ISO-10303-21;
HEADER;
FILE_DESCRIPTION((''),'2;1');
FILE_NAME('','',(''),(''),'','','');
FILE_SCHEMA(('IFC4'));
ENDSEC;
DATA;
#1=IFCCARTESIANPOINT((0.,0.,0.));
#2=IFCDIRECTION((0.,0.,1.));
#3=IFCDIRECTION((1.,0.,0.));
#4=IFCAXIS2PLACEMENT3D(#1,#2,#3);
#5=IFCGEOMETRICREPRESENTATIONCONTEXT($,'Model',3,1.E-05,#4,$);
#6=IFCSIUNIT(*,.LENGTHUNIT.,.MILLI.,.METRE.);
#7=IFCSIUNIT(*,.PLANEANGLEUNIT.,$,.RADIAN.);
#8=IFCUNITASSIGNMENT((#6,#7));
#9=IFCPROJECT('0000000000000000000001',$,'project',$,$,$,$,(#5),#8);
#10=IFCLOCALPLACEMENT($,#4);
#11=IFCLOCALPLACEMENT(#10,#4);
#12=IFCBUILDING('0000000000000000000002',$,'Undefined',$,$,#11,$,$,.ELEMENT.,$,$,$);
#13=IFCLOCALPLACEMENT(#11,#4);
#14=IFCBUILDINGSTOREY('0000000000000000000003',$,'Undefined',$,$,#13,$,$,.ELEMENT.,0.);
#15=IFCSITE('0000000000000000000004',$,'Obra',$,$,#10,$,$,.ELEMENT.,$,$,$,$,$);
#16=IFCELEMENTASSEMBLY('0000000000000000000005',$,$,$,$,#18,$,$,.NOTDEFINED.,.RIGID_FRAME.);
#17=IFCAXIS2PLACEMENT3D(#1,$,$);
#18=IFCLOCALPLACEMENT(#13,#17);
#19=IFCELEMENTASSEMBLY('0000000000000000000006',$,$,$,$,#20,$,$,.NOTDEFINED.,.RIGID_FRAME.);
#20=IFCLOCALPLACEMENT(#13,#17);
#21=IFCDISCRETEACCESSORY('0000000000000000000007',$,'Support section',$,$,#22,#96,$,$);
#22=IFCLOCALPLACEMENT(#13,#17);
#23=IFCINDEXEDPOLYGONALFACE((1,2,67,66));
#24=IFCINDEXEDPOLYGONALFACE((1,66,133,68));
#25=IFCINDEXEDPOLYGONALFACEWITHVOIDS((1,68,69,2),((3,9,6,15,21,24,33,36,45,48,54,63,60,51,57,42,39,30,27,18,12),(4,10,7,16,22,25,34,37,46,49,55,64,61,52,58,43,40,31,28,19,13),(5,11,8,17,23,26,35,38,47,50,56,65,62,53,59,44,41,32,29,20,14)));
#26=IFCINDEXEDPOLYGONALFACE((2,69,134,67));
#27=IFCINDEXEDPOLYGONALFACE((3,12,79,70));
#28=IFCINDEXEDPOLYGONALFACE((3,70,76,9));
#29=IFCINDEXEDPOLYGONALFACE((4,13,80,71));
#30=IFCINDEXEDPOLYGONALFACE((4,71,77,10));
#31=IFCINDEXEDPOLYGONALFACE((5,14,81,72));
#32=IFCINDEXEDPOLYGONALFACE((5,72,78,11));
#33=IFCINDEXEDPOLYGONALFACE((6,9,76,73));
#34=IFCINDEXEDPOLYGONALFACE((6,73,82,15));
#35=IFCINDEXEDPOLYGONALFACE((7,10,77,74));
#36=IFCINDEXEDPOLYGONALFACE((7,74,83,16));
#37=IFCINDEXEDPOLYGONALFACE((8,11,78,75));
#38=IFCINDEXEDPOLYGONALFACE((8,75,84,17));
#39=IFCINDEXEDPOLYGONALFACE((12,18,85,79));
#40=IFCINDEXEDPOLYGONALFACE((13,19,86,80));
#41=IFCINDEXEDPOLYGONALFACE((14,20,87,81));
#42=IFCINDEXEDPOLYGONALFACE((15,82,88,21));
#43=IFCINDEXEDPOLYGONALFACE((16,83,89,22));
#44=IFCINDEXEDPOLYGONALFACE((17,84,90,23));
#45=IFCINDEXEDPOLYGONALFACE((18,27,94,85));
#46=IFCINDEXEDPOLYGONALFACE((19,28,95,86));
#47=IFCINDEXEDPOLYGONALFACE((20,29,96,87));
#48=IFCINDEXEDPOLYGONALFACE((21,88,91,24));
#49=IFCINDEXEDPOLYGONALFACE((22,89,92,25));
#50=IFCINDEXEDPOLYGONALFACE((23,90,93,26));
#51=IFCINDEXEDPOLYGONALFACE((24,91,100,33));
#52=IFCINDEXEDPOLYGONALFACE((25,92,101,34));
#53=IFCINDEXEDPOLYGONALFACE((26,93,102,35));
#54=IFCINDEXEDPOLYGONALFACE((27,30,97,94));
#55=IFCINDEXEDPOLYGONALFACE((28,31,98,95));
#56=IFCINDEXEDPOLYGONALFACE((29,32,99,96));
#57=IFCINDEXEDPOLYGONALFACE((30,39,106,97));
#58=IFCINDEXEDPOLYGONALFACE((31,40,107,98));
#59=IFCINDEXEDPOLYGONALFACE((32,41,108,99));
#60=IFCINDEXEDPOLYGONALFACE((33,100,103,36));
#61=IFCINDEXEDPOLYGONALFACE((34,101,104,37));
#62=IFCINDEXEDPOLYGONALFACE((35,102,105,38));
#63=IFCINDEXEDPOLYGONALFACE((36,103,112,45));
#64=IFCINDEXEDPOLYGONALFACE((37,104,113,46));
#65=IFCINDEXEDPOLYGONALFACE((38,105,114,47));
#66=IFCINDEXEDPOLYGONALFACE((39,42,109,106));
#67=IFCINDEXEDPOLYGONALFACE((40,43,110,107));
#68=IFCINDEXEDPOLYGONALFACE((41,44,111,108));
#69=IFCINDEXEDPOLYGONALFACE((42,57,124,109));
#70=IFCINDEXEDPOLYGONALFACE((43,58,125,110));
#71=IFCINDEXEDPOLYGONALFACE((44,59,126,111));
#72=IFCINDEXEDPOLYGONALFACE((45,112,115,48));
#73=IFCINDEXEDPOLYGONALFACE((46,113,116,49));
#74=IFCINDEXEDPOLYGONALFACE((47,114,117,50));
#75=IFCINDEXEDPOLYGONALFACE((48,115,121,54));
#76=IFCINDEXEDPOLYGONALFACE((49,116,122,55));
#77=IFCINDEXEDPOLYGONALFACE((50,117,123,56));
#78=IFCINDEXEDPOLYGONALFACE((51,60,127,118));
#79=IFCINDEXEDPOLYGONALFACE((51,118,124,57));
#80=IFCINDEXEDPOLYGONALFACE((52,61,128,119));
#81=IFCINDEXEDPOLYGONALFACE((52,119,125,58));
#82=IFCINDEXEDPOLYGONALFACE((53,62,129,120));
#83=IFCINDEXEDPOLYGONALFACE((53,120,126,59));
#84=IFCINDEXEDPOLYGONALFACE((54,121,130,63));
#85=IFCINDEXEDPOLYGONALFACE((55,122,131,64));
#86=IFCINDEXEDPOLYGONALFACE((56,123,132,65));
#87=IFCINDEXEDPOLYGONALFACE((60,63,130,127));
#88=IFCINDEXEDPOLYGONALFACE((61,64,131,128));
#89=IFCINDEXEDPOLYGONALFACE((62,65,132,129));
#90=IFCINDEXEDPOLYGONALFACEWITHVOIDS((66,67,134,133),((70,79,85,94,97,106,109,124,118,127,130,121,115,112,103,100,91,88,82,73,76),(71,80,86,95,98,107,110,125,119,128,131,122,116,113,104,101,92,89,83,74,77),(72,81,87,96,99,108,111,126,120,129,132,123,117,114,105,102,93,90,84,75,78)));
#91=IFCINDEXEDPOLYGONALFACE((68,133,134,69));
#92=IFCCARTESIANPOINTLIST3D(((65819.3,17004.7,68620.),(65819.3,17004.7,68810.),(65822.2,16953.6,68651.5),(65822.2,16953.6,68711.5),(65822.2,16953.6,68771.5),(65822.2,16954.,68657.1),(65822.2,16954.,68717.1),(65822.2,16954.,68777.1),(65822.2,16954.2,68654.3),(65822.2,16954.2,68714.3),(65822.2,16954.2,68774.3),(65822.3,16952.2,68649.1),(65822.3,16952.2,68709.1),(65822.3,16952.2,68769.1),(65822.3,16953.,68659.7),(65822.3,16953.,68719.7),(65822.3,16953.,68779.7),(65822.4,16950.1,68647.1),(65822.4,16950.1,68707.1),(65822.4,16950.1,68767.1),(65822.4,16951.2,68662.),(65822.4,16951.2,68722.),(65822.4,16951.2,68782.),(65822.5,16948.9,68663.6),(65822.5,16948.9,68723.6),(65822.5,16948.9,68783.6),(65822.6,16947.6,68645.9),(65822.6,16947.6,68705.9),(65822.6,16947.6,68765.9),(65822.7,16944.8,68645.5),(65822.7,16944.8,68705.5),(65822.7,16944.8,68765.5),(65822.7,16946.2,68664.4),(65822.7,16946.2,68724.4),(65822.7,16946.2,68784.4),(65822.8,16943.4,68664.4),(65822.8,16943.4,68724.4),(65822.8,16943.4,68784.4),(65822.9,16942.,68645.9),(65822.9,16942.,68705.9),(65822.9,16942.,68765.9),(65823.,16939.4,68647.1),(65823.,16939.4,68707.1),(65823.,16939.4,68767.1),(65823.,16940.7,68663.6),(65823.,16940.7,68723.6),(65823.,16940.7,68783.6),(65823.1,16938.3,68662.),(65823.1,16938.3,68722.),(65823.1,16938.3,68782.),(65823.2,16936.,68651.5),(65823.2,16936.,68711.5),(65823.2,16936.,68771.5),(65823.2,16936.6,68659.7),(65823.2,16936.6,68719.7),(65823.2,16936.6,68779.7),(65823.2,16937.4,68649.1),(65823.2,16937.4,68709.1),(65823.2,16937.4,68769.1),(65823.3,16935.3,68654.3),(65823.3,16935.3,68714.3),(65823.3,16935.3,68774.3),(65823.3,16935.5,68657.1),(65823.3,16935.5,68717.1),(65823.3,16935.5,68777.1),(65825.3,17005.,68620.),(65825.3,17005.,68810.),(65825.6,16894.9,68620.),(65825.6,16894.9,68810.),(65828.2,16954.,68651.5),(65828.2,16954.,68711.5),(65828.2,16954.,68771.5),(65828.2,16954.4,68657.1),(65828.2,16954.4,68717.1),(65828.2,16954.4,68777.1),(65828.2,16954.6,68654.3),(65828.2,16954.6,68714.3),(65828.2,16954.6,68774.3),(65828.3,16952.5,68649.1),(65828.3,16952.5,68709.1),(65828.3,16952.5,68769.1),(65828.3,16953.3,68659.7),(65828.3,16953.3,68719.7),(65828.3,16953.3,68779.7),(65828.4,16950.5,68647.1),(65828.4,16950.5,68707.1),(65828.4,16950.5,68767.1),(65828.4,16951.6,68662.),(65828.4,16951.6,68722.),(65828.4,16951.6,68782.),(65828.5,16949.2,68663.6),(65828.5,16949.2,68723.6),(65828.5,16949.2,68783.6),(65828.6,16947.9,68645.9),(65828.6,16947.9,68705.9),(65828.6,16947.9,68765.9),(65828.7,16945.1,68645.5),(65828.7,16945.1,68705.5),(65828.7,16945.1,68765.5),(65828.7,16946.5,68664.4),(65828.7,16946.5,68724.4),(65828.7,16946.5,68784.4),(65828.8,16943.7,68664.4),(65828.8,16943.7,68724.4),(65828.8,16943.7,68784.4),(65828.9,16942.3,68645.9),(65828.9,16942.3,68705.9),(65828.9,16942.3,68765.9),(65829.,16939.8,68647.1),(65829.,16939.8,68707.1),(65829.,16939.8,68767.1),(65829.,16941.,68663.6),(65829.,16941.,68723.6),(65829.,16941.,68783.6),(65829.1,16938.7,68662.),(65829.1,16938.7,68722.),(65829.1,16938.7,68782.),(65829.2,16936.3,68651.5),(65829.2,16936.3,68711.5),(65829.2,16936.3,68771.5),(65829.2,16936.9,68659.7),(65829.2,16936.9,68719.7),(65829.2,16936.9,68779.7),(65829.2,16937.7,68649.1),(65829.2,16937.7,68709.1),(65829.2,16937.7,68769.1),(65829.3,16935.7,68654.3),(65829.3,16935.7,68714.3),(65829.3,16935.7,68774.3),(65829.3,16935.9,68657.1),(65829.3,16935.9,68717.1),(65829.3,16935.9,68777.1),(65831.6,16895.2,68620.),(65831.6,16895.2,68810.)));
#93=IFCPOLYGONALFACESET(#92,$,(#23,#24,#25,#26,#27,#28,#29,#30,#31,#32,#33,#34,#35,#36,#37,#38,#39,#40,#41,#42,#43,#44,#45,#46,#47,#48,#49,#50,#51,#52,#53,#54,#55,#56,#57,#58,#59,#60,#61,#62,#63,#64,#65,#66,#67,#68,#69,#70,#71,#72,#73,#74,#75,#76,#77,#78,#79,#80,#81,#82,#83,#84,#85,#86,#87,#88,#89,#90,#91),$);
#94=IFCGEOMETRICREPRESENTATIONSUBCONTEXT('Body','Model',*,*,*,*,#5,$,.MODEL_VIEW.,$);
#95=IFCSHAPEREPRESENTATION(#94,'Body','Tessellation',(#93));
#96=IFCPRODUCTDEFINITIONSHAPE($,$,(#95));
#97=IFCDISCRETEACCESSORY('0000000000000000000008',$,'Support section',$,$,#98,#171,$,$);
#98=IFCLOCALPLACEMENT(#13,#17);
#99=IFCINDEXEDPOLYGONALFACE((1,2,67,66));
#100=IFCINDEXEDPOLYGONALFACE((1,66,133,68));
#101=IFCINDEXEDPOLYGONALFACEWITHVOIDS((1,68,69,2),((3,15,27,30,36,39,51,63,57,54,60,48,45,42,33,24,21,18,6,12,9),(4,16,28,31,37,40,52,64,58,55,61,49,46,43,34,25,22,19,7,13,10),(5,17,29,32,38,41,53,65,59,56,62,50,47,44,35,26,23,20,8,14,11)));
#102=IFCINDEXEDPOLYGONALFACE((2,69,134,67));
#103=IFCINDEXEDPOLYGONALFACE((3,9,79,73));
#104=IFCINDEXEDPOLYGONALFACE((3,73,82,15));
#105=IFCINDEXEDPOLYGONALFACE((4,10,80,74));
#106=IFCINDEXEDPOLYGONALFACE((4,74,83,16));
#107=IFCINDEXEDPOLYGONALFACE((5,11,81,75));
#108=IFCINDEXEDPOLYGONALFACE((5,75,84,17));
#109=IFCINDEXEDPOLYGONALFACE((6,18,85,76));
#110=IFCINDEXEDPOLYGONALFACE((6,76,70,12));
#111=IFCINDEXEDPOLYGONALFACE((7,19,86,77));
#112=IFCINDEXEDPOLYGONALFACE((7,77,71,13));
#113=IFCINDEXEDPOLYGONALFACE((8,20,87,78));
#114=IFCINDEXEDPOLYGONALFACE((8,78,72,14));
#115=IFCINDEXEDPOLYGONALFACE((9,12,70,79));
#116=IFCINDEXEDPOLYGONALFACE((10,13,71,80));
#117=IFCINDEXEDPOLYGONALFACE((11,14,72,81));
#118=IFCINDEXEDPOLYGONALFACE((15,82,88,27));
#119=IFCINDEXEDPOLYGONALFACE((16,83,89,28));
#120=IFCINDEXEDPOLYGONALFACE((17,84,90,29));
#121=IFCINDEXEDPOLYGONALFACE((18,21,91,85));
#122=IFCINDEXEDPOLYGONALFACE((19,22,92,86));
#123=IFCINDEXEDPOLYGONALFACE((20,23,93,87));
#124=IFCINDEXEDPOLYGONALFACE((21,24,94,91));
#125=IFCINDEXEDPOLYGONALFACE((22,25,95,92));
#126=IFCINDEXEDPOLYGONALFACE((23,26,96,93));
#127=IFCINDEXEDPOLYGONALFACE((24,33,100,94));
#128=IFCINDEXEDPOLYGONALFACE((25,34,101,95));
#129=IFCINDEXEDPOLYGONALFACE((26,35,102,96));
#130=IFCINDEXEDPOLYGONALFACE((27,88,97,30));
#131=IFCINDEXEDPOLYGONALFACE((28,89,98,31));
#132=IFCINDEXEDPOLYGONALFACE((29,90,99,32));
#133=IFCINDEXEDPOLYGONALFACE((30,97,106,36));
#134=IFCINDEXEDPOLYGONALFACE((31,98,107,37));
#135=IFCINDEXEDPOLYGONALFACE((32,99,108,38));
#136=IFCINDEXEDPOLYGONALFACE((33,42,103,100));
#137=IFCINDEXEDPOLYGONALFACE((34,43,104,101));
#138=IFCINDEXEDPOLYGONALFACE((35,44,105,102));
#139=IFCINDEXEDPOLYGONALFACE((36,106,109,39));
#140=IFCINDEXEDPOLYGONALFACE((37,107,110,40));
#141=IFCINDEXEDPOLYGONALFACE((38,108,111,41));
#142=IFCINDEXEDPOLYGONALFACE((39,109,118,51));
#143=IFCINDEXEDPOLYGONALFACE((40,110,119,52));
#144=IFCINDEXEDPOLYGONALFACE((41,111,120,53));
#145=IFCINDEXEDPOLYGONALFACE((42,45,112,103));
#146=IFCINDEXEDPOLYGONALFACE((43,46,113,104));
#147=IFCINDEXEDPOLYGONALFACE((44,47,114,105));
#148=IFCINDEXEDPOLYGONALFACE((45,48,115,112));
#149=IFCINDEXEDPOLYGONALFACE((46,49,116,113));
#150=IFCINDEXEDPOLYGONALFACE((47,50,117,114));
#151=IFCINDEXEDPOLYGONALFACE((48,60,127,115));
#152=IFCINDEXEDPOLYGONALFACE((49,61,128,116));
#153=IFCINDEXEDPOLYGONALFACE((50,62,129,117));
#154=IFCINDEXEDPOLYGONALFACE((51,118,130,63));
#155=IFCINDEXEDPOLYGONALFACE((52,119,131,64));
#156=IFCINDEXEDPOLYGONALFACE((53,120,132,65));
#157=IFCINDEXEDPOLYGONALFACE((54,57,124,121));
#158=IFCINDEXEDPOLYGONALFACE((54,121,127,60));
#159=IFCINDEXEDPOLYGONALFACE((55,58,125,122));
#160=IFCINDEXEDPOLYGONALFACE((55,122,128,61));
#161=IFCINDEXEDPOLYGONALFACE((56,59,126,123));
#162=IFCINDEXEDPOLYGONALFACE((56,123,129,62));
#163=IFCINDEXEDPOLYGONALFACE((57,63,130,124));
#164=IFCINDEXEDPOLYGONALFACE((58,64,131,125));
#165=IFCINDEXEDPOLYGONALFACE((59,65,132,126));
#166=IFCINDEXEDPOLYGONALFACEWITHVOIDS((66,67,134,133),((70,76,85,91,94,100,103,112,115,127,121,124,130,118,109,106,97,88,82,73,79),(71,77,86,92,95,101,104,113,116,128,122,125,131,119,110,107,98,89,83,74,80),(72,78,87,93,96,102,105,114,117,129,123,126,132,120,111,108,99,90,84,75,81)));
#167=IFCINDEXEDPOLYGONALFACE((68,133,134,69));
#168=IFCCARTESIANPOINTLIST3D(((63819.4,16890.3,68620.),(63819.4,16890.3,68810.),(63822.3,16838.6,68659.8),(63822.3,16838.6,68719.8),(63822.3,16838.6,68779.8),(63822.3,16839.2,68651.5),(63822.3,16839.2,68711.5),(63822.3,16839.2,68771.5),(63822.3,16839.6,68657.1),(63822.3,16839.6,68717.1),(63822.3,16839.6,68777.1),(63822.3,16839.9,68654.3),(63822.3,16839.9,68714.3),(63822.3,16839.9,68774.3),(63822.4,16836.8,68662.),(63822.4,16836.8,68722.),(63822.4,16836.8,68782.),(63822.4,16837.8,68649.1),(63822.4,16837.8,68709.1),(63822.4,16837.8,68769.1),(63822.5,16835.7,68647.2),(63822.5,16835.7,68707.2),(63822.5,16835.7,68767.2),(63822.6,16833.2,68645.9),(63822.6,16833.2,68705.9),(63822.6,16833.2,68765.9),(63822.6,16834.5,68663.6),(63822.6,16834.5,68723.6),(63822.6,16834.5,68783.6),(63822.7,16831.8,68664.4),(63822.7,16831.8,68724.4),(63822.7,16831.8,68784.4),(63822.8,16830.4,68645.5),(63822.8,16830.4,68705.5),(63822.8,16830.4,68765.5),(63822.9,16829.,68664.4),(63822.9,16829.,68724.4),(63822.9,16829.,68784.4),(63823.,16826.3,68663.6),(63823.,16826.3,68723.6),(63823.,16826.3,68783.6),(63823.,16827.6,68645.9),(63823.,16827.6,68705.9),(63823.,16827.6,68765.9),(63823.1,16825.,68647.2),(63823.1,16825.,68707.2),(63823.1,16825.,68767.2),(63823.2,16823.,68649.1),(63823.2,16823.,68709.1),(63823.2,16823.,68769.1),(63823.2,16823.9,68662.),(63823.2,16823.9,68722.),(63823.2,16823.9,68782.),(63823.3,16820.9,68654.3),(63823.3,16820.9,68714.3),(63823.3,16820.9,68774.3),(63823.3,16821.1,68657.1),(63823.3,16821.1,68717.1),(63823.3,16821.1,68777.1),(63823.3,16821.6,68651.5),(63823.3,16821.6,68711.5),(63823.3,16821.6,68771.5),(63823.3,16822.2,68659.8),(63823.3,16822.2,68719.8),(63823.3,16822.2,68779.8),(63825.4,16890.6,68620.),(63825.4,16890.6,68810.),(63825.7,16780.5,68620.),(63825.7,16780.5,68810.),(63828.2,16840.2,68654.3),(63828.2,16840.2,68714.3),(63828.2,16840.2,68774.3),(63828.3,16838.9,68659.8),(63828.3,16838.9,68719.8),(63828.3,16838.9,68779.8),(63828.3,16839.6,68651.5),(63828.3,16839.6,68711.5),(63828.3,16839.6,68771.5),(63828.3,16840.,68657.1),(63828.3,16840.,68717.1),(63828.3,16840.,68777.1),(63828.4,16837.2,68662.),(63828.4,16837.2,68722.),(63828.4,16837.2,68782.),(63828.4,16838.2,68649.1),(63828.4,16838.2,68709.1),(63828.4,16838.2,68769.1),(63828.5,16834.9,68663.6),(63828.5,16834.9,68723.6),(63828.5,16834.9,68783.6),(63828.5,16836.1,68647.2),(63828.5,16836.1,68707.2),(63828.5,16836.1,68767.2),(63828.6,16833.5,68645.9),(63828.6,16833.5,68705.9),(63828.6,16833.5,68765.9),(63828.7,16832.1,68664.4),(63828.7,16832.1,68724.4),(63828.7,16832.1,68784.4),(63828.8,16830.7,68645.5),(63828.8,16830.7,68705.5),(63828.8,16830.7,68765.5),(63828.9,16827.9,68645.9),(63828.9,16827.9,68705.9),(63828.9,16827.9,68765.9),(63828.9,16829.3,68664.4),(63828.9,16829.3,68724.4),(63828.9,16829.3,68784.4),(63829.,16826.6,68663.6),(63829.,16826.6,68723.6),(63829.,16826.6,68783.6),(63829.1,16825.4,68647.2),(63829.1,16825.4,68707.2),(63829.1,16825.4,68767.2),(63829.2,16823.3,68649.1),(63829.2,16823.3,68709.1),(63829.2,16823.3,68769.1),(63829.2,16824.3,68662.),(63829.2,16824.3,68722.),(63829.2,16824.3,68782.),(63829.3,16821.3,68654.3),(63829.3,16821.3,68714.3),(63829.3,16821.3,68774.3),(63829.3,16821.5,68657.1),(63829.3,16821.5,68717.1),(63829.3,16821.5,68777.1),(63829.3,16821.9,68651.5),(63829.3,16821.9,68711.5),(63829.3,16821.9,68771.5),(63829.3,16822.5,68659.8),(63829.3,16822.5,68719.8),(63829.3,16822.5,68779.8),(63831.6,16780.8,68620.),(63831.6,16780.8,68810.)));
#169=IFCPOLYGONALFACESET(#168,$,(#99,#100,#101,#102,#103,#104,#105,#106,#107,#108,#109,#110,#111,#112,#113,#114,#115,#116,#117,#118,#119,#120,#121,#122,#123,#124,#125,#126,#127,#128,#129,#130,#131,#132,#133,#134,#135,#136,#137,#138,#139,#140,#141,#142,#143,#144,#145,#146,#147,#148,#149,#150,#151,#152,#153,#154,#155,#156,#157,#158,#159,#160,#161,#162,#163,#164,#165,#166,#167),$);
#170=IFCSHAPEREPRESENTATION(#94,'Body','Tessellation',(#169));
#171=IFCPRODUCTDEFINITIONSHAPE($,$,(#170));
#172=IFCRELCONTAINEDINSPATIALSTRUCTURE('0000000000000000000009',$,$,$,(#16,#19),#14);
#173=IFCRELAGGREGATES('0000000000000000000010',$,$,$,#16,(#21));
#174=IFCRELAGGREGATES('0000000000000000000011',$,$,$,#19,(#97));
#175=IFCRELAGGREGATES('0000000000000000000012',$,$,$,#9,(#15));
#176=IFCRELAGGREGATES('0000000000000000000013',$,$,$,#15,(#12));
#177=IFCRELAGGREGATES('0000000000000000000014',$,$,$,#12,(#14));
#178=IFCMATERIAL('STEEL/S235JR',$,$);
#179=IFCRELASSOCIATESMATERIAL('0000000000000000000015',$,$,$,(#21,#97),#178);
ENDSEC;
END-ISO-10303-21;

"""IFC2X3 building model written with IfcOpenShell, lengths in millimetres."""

from ifc_helpers import new_model, si_unit, frame, origin_with_axes, origin_2d_with_axis, place, context, subcontext, project, spatial, rectangle, circle, extrude, source, transform, mapped, material, element, aggregate, save


model = new_model("IFC2X3")

# Units and contexts
model_context = context("Model", 3, precision=1e-05, world=origin_with_axes())
body_context = subcontext(model_context, "Body", "Model", "MODEL_VIEW")
ifc_project = project(units=[si_unit("LENGTHUNIT", "METRE", prefix="MILLI"), si_unit("PLANEANGLEUNIT", "RADIAN")], contexts=[model_context])

# Site, building, storey
site_placement = place(None, origin_with_axes())
site = spatial("IfcSite", under=ifc_project, at=site_placement, Name="Obra", CompositionType="ELEMENT")
building_placement = place(site_placement, origin_with_axes())
building = spatial("IfcBuilding", under=site, at=building_placement, Name="Undefined", CompositionType="ELEMENT")
storey_placement = place(building_placement, origin_with_axes())
storey = spatial("IfcBuildingStorey", under=building, at=storey_placement, Name="Undefined", CompositionType="ELEMENT", Elevation=0.0)

# Element assemblies
ifc_material = material(Name="STEEL/S235JR")
assembly_1_placement = place(storey_placement, origin_with_axes())
assembly_1 = element("IfcElementAssembly", 1, at=assembly_1_placement, inside=storey, AssemblyPlace="NOTDEFINED", PredefinedType="RIGID_FRAME")
assembly_2_placement = place(storey_placement, origin_with_axes())
assembly_2 = element("IfcElementAssembly", 2, at=assembly_2_placement, inside=storey, AssemblyPlace="NOTDEFINED", PredefinedType="RIGID_FRAME")

# Shared definitions
shared_shape_1 = source(origin_with_axes(), body_context, "Body", "SweptSolid", [
    extrude(circle(Radius=9.5, at=origin_2d_with_axis()), frame((0.0, -9.2, 0.0), z_axis=(0.0, 1.0, 0.0), x_axis=(1.0, 0.0, 0.0)), (0.0, 0.0, 1.0), 6.2),
])

# Discrete accessories, openings
discrete_accessory_1_placement = place(assembly_1_placement, frame((65825.5, 16950.0, 68620.0), z_axis=(0.0, 0.0, 1.0), x_axis=(-0.057107, 0.998368, 0.0)))
discrete_accessory_1 = element("IfcDiscreteAccessory", 3, at=discrete_accessory_1_placement, material=ifc_material, Name="Support section", context=body_context, shape_type="SweptSolid", body=[
    extrude(rectangle(XDim=6.0, YDim=110.0, at=origin_2d_with_axis()), frame((0.0, 0.0, 190.0), z_axis=(0.0, 0.0, -1.0), x_axis=(0.0, 1.0, 0.0)), (0.0, 0.0, 1.0), 190.0),
])
opening_1_placement = place(assembly_1_placement, frame((65829.0, 16995.2, 68835.0), z_axis=(0.057107, -0.998368, 0.0), x_axis=(0.0, 0.0, -1.0)))
element("IfcOpeningElement", 4, at=opening_1_placement, cuts=discrete_accessory_1, ObjectType="Opening", context=body_context, shape_type="MappedRepresentation", body=[
    mapped(shared_shape_1, transform((60.0, 0.0, 50.0))),
    mapped(shared_shape_1, transform((120.0, 0.0, 50.0))),
    mapped(shared_shape_1, transform((180.0, 0.0, 50.0))),
])
aggregate(assembly_1, [discrete_accessory_1])
discrete_accessory_2_placement = place(assembly_2_placement, frame((63825.5, 16835.6, 68620.0), z_axis=(0.0, 0.0, 1.0), x_axis=(-0.057107, 0.998368, 0.0)))
discrete_accessory_2 = element("IfcDiscreteAccessory", 5, at=discrete_accessory_2_placement, material=ifc_material, Name="Support section", context=body_context, shape_type="SweptSolid", body=[
    extrude(rectangle(XDim=6.0, YDim=110.0, at=origin_2d_with_axis()), frame((0.0, 0.0, 190.0), z_axis=(0.0, 0.0, -1.0), x_axis=(0.0, 1.0, 0.0)), (0.0, 0.0, 1.0), 190.0),
])
opening_2_placement = place(assembly_2_placement, frame((63829.0, 16880.8, 68835.0), z_axis=(0.057107, -0.998368, 0.0), x_axis=(0.0, 0.0, -1.0)))
element("IfcOpeningElement", 6, at=opening_2_placement, cuts=discrete_accessory_2, ObjectType="Opening", context=body_context, shape_type="MappedRepresentation", body=[
    mapped(shared_shape_1, transform((60.0, 0.0, 50.0))),
    mapped(shared_shape_1, transform((120.0, 0.0, 50.0))),
    mapped(shared_shape_1, transform((180.0, 0.0, 50.0))),
])
aggregate(assembly_2, [discrete_accessory_2])

save(model, "model.ifc")
